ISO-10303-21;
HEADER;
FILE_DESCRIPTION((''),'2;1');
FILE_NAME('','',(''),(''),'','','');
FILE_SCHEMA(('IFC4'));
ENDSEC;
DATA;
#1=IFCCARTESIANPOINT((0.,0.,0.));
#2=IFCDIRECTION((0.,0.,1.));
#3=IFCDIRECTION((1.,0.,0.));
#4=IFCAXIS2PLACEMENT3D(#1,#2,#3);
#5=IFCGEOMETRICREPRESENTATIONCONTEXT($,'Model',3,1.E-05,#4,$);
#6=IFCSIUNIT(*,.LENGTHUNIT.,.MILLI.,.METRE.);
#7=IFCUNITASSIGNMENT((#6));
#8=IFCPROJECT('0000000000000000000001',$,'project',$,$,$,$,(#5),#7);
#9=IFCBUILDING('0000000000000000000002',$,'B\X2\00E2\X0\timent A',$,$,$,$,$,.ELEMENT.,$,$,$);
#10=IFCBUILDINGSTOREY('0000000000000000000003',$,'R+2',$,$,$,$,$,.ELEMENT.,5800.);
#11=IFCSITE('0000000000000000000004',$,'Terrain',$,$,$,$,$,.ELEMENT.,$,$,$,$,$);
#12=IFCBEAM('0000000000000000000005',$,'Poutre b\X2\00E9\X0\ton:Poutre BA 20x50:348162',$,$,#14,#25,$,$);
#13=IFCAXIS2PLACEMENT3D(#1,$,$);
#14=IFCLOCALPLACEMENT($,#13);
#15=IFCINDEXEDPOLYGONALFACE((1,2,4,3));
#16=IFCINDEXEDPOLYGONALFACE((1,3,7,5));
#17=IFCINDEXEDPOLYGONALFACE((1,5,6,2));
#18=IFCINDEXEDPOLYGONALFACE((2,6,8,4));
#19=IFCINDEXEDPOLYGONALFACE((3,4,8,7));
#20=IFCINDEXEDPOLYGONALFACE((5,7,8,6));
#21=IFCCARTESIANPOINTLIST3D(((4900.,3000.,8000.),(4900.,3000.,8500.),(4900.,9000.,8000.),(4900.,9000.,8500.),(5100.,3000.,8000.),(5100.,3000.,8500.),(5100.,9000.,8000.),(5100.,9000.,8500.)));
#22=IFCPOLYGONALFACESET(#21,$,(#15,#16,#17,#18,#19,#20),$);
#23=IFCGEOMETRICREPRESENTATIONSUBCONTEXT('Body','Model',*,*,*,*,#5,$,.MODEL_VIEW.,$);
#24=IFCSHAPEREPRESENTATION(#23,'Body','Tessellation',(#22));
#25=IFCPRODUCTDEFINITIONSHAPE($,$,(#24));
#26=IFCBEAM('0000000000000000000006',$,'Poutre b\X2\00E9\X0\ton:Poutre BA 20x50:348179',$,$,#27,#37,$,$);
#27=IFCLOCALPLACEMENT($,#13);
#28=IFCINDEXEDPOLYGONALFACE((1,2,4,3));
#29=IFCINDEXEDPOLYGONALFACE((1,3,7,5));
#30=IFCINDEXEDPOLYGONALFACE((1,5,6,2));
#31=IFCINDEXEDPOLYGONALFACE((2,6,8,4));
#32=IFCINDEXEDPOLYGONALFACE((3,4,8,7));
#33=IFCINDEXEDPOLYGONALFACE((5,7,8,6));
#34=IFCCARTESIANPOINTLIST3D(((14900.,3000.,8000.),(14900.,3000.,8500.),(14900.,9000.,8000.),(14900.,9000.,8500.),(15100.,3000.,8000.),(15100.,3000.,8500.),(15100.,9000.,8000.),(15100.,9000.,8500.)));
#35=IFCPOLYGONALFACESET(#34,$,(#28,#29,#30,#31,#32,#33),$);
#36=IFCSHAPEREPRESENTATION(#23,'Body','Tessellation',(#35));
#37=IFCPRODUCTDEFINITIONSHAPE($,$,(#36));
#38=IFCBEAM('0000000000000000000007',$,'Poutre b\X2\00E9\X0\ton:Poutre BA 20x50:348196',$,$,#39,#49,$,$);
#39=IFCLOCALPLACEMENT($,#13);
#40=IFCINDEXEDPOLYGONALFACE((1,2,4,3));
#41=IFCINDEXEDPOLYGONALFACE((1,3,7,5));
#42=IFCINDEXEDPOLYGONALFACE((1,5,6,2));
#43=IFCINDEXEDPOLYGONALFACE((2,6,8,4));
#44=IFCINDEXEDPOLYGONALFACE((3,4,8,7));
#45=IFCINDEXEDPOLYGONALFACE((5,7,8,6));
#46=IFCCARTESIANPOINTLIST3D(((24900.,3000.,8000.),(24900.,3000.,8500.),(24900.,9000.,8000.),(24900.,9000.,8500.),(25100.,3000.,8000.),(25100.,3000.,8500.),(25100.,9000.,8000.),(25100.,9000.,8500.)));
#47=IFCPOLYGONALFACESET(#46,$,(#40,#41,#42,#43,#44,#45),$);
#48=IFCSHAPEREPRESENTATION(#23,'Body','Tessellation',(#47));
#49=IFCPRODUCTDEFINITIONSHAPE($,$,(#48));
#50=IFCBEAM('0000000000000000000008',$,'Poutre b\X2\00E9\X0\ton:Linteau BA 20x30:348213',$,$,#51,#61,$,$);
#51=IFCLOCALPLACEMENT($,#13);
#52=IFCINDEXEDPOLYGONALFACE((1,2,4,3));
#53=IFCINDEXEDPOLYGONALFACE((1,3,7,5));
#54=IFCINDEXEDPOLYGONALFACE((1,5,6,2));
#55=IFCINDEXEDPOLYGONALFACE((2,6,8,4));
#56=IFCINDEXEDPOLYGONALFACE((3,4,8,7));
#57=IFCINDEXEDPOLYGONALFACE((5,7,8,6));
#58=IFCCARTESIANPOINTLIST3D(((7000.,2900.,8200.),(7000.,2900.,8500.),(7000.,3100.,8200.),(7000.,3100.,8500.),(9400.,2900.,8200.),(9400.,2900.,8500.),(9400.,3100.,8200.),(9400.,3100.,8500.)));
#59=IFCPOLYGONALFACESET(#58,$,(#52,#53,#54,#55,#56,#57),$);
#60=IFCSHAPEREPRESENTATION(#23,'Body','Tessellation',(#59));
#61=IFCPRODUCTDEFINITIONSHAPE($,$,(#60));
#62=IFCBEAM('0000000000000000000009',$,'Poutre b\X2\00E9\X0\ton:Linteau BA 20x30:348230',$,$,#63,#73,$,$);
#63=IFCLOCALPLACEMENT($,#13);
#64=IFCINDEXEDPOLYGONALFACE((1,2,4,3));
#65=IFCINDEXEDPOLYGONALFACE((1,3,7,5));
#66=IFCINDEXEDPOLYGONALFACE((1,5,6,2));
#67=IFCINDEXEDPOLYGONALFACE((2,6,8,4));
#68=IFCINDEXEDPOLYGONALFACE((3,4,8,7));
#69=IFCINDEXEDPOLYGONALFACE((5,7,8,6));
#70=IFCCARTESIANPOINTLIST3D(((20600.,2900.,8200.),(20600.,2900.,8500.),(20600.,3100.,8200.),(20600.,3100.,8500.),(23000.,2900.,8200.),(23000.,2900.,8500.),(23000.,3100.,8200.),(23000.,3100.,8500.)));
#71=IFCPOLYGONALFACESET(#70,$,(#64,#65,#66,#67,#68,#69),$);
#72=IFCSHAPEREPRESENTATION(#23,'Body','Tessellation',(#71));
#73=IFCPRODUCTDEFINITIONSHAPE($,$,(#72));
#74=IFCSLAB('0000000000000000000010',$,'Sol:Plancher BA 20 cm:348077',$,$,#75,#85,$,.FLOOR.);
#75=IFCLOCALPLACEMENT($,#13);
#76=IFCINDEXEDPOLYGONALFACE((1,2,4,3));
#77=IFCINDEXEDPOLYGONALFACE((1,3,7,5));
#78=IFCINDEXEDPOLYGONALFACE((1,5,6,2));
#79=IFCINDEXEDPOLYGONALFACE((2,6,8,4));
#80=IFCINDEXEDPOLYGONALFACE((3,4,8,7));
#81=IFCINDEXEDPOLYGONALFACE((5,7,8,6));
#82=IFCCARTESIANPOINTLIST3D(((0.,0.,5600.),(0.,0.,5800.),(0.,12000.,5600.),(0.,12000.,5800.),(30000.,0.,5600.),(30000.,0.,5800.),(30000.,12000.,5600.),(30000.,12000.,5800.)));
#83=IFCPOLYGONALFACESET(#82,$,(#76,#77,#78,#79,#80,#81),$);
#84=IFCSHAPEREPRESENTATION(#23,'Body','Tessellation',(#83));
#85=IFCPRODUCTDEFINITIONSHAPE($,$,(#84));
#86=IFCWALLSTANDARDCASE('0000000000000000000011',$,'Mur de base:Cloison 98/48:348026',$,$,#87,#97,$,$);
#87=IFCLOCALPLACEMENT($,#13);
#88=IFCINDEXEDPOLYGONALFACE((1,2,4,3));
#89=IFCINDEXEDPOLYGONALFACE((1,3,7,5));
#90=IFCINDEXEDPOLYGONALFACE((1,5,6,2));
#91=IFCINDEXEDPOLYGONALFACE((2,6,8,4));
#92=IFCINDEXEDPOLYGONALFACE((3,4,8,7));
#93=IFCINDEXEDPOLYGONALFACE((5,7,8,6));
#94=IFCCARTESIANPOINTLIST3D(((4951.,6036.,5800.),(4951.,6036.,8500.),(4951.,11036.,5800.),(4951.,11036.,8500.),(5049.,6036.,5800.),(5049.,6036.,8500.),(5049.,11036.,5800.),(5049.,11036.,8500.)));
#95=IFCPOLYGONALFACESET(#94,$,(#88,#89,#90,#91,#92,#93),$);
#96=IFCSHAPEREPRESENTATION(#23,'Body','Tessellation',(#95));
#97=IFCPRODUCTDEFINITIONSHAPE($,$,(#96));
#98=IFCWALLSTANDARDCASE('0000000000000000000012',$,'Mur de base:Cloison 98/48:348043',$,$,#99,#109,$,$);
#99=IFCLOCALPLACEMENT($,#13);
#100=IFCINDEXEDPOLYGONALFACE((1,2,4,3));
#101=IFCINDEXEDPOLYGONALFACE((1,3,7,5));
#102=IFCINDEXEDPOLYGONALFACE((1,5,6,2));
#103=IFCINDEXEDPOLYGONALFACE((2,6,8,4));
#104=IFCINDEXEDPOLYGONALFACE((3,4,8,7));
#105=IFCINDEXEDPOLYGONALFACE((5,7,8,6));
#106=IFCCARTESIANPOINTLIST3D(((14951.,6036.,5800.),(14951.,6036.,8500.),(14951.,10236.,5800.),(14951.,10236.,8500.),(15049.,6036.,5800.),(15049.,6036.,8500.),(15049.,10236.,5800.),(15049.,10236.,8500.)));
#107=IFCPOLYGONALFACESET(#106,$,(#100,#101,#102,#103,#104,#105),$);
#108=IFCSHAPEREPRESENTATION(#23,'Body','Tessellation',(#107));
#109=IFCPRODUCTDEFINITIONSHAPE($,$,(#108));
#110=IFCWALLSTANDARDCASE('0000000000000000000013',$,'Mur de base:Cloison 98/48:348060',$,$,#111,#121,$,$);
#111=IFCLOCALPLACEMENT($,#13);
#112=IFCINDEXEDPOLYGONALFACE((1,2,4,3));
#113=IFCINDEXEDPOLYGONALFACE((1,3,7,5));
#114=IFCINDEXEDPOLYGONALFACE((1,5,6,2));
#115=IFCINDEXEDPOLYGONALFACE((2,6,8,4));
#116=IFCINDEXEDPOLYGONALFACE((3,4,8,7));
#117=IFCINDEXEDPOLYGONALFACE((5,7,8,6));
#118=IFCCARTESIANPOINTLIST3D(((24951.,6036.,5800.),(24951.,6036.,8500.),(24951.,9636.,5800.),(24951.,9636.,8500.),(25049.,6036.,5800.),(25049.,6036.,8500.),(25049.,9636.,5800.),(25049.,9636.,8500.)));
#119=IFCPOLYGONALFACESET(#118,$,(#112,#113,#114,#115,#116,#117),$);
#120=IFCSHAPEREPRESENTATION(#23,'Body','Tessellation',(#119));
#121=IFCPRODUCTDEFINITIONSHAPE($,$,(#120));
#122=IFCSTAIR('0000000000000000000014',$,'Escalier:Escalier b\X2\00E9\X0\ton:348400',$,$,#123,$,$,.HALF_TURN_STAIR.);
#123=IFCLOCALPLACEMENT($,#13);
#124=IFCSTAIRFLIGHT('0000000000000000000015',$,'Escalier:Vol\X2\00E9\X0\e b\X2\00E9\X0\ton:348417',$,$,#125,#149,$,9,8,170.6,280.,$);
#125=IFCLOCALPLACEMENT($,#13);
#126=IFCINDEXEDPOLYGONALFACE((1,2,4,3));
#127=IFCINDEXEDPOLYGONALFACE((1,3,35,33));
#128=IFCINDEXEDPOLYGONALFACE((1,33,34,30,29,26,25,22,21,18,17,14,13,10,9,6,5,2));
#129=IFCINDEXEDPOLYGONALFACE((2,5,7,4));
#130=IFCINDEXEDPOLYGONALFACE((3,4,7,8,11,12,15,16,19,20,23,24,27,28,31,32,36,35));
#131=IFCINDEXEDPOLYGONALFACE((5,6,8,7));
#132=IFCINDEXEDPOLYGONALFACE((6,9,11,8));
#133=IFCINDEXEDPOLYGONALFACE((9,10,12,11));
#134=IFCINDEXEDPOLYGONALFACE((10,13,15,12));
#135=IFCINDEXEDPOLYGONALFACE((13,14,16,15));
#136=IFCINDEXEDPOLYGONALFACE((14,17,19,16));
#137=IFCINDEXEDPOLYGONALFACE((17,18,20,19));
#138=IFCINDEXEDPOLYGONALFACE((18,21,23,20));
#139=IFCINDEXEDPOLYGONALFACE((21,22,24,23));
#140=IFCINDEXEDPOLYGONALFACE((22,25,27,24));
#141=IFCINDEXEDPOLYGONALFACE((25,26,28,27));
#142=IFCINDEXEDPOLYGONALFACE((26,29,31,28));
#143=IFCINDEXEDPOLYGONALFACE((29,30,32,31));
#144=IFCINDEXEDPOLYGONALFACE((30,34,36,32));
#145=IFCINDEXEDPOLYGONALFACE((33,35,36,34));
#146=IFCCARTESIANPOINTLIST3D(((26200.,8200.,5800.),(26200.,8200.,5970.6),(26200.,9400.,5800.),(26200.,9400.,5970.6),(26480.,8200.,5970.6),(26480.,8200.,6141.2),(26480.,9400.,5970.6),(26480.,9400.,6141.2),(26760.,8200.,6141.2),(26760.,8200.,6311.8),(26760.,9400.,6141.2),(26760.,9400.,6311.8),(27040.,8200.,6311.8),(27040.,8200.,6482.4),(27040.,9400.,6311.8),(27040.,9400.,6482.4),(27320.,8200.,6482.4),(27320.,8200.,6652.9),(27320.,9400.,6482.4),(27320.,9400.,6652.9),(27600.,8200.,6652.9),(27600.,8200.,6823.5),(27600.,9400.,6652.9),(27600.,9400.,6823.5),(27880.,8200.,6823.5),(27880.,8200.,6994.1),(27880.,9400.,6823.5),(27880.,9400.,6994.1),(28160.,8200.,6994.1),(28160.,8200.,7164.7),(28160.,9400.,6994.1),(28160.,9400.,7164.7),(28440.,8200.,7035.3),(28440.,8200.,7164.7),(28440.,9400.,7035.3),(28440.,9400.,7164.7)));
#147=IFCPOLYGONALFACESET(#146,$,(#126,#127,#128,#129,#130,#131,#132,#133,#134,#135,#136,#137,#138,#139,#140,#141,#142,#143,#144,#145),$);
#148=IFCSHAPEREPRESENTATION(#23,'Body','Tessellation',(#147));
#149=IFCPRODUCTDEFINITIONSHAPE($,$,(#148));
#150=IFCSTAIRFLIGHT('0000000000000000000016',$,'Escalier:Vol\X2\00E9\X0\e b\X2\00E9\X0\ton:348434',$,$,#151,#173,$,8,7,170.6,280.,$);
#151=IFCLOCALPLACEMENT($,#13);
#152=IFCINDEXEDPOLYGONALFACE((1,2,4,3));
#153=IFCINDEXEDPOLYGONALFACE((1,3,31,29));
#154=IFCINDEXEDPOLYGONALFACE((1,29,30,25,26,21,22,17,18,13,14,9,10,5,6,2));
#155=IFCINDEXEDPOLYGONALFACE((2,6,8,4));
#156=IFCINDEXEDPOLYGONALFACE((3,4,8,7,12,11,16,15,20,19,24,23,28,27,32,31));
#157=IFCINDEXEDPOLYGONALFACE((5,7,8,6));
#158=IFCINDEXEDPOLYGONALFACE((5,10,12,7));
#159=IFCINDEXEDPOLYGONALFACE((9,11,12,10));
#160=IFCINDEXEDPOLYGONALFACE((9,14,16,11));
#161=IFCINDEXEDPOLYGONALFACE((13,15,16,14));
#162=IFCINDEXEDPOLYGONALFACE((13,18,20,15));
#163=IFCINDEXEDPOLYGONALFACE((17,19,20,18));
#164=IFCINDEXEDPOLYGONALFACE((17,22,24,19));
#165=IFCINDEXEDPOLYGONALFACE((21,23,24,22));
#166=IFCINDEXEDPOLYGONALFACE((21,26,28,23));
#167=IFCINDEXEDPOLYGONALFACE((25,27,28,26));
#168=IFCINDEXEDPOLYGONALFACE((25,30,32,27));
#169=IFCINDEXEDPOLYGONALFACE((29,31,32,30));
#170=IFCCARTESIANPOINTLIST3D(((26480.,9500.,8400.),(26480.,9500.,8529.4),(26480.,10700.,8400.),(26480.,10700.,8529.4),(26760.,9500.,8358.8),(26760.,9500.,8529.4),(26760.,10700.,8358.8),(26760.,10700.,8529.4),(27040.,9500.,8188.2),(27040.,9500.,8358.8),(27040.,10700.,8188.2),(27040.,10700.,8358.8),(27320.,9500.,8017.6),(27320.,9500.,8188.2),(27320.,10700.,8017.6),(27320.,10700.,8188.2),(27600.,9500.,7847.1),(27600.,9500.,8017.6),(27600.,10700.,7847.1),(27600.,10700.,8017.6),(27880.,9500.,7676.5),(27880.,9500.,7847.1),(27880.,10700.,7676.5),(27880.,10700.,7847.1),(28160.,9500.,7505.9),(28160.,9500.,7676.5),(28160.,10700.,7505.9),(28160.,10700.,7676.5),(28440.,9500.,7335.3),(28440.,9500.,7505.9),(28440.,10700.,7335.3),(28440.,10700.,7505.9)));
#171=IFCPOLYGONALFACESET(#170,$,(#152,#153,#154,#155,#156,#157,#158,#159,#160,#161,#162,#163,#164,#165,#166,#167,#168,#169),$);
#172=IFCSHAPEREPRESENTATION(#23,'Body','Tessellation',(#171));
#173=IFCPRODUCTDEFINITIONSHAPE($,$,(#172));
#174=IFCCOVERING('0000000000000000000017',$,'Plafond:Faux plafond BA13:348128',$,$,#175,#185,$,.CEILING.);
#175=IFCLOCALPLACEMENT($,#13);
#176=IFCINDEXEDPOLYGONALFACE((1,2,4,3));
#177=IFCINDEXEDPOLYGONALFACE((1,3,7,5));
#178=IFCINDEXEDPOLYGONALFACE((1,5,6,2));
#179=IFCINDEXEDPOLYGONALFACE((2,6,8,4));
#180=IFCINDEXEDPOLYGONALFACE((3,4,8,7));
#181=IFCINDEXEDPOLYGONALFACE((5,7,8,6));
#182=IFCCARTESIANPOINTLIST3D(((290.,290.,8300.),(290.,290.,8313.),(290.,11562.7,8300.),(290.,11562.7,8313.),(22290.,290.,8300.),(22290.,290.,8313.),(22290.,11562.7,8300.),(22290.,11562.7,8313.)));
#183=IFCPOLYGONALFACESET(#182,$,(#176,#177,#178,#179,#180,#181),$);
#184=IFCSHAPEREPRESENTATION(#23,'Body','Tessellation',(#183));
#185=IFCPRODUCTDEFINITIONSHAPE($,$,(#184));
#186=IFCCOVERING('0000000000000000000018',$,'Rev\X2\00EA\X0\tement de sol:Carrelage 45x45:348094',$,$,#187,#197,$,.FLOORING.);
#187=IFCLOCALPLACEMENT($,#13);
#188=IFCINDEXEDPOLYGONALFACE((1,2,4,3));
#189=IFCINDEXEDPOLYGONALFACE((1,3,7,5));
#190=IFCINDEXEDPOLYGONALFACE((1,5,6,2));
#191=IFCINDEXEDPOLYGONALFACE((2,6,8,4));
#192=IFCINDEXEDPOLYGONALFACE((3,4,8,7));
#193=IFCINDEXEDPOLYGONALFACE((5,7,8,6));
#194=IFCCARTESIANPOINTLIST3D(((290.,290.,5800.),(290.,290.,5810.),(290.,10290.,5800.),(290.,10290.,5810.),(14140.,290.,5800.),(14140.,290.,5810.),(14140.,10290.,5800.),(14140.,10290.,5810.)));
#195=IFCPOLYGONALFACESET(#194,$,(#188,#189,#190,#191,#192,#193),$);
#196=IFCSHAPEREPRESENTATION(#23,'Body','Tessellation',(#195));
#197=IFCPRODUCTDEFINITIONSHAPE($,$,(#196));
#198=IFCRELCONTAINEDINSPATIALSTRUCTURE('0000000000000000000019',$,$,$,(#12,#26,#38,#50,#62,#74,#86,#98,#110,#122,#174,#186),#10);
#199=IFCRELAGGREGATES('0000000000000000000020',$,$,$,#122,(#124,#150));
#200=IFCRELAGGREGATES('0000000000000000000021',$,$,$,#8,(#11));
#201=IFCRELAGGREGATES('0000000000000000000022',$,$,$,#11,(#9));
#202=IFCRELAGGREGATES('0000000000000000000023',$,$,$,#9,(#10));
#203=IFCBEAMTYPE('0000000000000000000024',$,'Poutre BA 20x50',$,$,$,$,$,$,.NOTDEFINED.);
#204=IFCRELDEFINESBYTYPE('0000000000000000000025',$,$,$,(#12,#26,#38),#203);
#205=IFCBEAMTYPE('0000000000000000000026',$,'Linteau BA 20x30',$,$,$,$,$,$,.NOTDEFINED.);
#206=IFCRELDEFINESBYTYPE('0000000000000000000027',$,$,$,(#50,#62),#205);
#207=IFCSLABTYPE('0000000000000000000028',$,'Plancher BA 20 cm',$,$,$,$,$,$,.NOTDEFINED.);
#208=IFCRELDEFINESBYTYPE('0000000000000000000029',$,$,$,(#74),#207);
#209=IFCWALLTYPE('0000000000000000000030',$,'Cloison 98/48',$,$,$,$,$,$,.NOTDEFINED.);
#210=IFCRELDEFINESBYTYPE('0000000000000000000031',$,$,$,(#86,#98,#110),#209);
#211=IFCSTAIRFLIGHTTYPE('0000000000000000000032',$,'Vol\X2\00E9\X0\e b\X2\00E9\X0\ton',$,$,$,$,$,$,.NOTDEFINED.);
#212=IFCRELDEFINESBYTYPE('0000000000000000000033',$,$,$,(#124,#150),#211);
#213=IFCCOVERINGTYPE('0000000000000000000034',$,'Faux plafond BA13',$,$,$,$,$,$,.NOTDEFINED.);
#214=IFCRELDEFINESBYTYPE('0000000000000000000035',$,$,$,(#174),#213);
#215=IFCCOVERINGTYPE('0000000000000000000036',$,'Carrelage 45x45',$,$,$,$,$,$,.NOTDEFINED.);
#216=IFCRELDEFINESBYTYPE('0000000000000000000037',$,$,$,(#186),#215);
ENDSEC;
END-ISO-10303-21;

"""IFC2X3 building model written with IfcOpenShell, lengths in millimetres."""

from ifc_helpers import new_model, si_unit, frame, frame_2d, origin_with_axes, place, context, subcontext, project, spatial, polyline, rectangle, outline, extrude, type_object, element, aggregate, save


model = new_model("IFC2X3")

# Units and contexts
model_context = context("Model", 3, precision=1e-05, world=origin_with_axes())
body_context = subcontext(model_context, "Body", "Model", "MODEL_VIEW")
ifc_project = project(units=[si_unit("LENGTHUNIT", "METRE", prefix="MILLI")], contexts=[model_context])

# Site, building, storey
site = spatial("IfcSite", under=ifc_project, Name="Terrain", CompositionType="ELEMENT")
building = spatial("IfcBuilding", under=site, Name="Bâtiment A", CompositionType="ELEMENT")
storey = spatial("IfcBuildingStorey", under=building, Name="R+2", CompositionType="ELEMENT", Elevation=5800.0)

# Beams
beam_type_1 = type_object("IfcBeamType", Name="Poutre BA 20x50", PredefinedType="NOTDEFINED")
beam_1_placement = place(None, origin_with_axes())
element("IfcBeam", 1, at=beam_1_placement, inside=storey, type_object=beam_type_1, Name="Poutre béton:Poutre BA 20x50:348162", context=body_context, shape_type="SweptSolid", body=[
    extrude(rectangle(XDim=200.0, YDim=6000.0, at=frame_2d((5000.0, 6000.0))), frame((0.0, 0.0, 8000.0), z_axis=(0.0, 0.0, 1.0), x_axis=(1.0, 0.0, 0.0)), (0.0, 0.0, 1.0), 500.0),
])
beam_2_placement = place(None, origin_with_axes())
element("IfcBeam", 2, at=beam_2_placement, inside=storey, type_object=beam_type_1, Name="Poutre béton:Poutre BA 20x50:348179", context=body_context, shape_type="SweptSolid", body=[
    extrude(rectangle(XDim=200.0, YDim=6000.0, at=frame_2d((15000.0, 6000.0))), frame((0.0, 0.0, 8000.0), z_axis=(0.0, 0.0, 1.0), x_axis=(1.0, 0.0, 0.0)), (0.0, 0.0, 1.0), 500.0),
])
beam_3_placement = place(None, origin_with_axes())
element("IfcBeam", 3, at=beam_3_placement, inside=storey, type_object=beam_type_1, Name="Poutre béton:Poutre BA 20x50:348196", context=body_context, shape_type="SweptSolid", body=[
    extrude(rectangle(XDim=200.0, YDim=6000.0, at=frame_2d((25000.0, 6000.0))), frame((0.0, 0.0, 8000.0), z_axis=(0.0, 0.0, 1.0), x_axis=(1.0, 0.0, 0.0)), (0.0, 0.0, 1.0), 500.0),
])
beam_type_2 = type_object("IfcBeamType", Name="Linteau BA 20x30", PredefinedType="NOTDEFINED")
beam_4_placement = place(None, origin_with_axes())
element("IfcBeam", 4, at=beam_4_placement, inside=storey, type_object=beam_type_2, Name="Poutre béton:Linteau BA 20x30:348213", context=body_context, shape_type="SweptSolid", body=[
    extrude(rectangle(XDim=2400.0, YDim=200.0, at=frame_2d((8200.0, 3000.0))), frame((0.0, 0.0, 8200.0), z_axis=(0.0, 0.0, 1.0), x_axis=(1.0, 0.0, 0.0)), (0.0, 0.0, 1.0), 300.0),
])
beam_5_placement = place(None, origin_with_axes())
element("IfcBeam", 5, at=beam_5_placement, inside=storey, type_object=beam_type_2, Name="Poutre béton:Linteau BA 20x30:348230", context=body_context, shape_type="SweptSolid", body=[
    extrude(rectangle(XDim=2400.0, YDim=200.0, at=frame_2d((21800.0, 3000.0))), frame((0.0, 0.0, 8200.0), z_axis=(0.0, 0.0, 1.0), x_axis=(1.0, 0.0, 0.0)), (0.0, 0.0, 1.0), 300.0),
])

# Slab
slab_type = type_object("IfcSlabType", Name="Plancher BA 20 cm", PredefinedType="NOTDEFINED")
slab_placement = place(None, origin_with_axes())
element("IfcSlab", 6, at=slab_placement, inside=storey, type_object=slab_type, Name="Sol:Plancher BA 20 cm:348077", PredefinedType="FLOOR", context=body_context, shape_type="SweptSolid", body=[
    extrude(rectangle(XDim=30000.0, YDim=12000.0, at=frame_2d((15000.0, 6000.0))), frame((0.0, 0.0, 5600.0), z_axis=(0.0, 0.0, 1.0), x_axis=(1.0, 0.0, 0.0)), (0.0, 0.0, 1.0), 200.0),
])

# Walls
wall_type = type_object("IfcWallType", Name="Cloison 98/48", PredefinedType="NOTDEFINED")
wall_1_placement = place(None, origin_with_axes())
element("IfcWallStandardCase", 7, at=wall_1_placement, inside=storey, type_object=wall_type, Name="Mur de base:Cloison 98/48:348026", context=body_context, shape_type="SweptSolid", body=[
    extrude(rectangle(XDim=98.0, YDim=5000.0, at=frame_2d((5000.0, 8536.0))), frame((0.0, 0.0, 5800.0), z_axis=(0.0, 0.0, 1.0), x_axis=(1.0, 0.0, 0.0)), (0.0, 0.0, 1.0), 2700.0),
])
wall_2_placement = place(None, origin_with_axes())
element("IfcWallStandardCase", 8, at=wall_2_placement, inside=storey, type_object=wall_type, Name="Mur de base:Cloison 98/48:348043", context=body_context, shape_type="SweptSolid", body=[
    extrude(rectangle(XDim=98.0, YDim=4200.0, at=frame_2d((15000.0, 8136.0))), frame((0.0, 0.0, 5800.0), z_axis=(0.0, 0.0, 1.0), x_axis=(1.0, 0.0, 0.0)), (0.0, 0.0, 1.0), 2700.0),
])
wall_3_placement = place(None, origin_with_axes())
element("IfcWallStandardCase", 9, at=wall_3_placement, inside=storey, type_object=wall_type, Name="Mur de base:Cloison 98/48:348060", context=body_context, shape_type="SweptSolid", body=[
    extrude(rectangle(XDim=98.0, YDim=3600.0, at=frame_2d((25000.0, 7836.0))), frame((0.0, 0.0, 5800.0), z_axis=(0.0, 0.0, 1.0), x_axis=(1.0, 0.0, 0.0)), (0.0, 0.0, 1.0), 2700.0),
])

# Stair, stair flights
stair = element("IfcStair", 10, inside=storey, Name="Escalier:Escalier béton:348400", ShapeType="HALF_TURN_STAIR")
stair_flight_type = type_object("IfcStairFlightType", Name="Volée béton", PredefinedType="NOTDEFINED")
stair_flight_1_placement = place(None, origin_with_axes())
stair_flight_1 = element("IfcStairFlight", 11, at=stair_flight_1_placement, type_object=stair_flight_type, Name="Escalier:Volée béton:348417", NumberOfRiser=9, NumberOfTreads=8, RiserHeight=170.6, TreadLength=280.0, context=body_context, shape_type="SweptSolid", body=[
    extrude(outline(polyline([(0.0, 0.0), (0.0, 170.6), (280.0, 170.6), (280.0, 341.2), (560.0, 341.2), (560.0, 511.8), (840.0, 511.8), (840.0, 682.4), (1120.0, 682.4), (1120.0, 852.9), (1400.0, 852.9), (1400.0, 1023.5), (1680.0, 1023.5), (1680.0, 1194.1), (1960.0, 1194.1), (1960.0, 1364.7), (2240.0, 1364.7), (2240.0, 1535.3), (2240.0, 1235.3), (0.0, 0.0)])), frame((26200.0, 9400.0, 5800.0), z_axis=(0.0, -1.0, 0.0), x_axis=(1.0, 0.0, 0.0)), (0.0, 0.0, 1.0), 1200.0),
])
stair_flight_2_placement = place(None, origin_with_axes())
stair_flight_2 = element("IfcStairFlight", 12, at=stair_flight_2_placement, type_object=stair_flight_type, Name="Escalier:Volée béton:348434", NumberOfRiser=8, NumberOfTreads=7, RiserHeight=170.6, TreadLength=280.0, context=body_context, shape_type="SweptSolid", body=[
    extrude(outline(polyline([(0.0, 0.0), (0.0, 170.6), (280.0, 170.6), (280.0, 341.2), (560.0, 341.2), (560.0, 511.8), (840.0, 511.8), (840.0, 682.4), (1120.0, 682.4), (1120.0, 852.9), (1400.0, 852.9), (1400.0, 1023.5), (1680.0, 1023.5), (1680.0, 1194.1), (1960.0, 1194.1), (1960.0, 1364.7), (1960.0, 1064.7), (0.0, 0.0)])), frame((28440.0, 9500.0, 7335.3), z_axis=(0.0, 1.0, 0.0), x_axis=(-1.0, 0.0, 0.0)), (0.0, 0.0, 1.0), 1200.0),
])
aggregate(stair, [stair_flight_1, stair_flight_2])

# Coverings
covering_type_1 = type_object("IfcCoveringType", Name="Faux plafond BA13", PredefinedType="NOTDEFINED")
covering_1_placement = place(None, origin_with_axes())
element("IfcCovering", 13, at=covering_1_placement, inside=storey, type_object=covering_type_1, Name="Plafond:Faux plafond BA13:348128", PredefinedType="CEILING", context=body_context, shape_type="SweptSolid", body=[
    extrude(rectangle(XDim=22000.0, YDim=11272.7, at=frame_2d((11290.0, 5926.4))), frame((0.0, 0.0, 8300.0), z_axis=(0.0, 0.0, 1.0), x_axis=(1.0, 0.0, 0.0)), (0.0, 0.0, 1.0), 13.0),
])
covering_type_2 = type_object("IfcCoveringType", Name="Carrelage 45x45", PredefinedType="NOTDEFINED")
covering_2_placement = place(None, origin_with_axes())
element("IfcCovering", 14, at=covering_2_placement, inside=storey, type_object=covering_type_2, Name="Revêtement de sol:Carrelage 45x45:348094", PredefinedType="FLOORING", context=body_context, shape_type="SweptSolid", body=[
    extrude(rectangle(XDim=13850.0, YDim=10000.0, at=frame_2d((7215.0, 5290.0))), frame((0.0, 0.0, 5800.0), z_axis=(0.0, 0.0, 1.0), x_axis=(1.0, 0.0, 0.0)), (0.0, 0.0, 1.0), 10.0),
])

save(model, "model.ifc")
